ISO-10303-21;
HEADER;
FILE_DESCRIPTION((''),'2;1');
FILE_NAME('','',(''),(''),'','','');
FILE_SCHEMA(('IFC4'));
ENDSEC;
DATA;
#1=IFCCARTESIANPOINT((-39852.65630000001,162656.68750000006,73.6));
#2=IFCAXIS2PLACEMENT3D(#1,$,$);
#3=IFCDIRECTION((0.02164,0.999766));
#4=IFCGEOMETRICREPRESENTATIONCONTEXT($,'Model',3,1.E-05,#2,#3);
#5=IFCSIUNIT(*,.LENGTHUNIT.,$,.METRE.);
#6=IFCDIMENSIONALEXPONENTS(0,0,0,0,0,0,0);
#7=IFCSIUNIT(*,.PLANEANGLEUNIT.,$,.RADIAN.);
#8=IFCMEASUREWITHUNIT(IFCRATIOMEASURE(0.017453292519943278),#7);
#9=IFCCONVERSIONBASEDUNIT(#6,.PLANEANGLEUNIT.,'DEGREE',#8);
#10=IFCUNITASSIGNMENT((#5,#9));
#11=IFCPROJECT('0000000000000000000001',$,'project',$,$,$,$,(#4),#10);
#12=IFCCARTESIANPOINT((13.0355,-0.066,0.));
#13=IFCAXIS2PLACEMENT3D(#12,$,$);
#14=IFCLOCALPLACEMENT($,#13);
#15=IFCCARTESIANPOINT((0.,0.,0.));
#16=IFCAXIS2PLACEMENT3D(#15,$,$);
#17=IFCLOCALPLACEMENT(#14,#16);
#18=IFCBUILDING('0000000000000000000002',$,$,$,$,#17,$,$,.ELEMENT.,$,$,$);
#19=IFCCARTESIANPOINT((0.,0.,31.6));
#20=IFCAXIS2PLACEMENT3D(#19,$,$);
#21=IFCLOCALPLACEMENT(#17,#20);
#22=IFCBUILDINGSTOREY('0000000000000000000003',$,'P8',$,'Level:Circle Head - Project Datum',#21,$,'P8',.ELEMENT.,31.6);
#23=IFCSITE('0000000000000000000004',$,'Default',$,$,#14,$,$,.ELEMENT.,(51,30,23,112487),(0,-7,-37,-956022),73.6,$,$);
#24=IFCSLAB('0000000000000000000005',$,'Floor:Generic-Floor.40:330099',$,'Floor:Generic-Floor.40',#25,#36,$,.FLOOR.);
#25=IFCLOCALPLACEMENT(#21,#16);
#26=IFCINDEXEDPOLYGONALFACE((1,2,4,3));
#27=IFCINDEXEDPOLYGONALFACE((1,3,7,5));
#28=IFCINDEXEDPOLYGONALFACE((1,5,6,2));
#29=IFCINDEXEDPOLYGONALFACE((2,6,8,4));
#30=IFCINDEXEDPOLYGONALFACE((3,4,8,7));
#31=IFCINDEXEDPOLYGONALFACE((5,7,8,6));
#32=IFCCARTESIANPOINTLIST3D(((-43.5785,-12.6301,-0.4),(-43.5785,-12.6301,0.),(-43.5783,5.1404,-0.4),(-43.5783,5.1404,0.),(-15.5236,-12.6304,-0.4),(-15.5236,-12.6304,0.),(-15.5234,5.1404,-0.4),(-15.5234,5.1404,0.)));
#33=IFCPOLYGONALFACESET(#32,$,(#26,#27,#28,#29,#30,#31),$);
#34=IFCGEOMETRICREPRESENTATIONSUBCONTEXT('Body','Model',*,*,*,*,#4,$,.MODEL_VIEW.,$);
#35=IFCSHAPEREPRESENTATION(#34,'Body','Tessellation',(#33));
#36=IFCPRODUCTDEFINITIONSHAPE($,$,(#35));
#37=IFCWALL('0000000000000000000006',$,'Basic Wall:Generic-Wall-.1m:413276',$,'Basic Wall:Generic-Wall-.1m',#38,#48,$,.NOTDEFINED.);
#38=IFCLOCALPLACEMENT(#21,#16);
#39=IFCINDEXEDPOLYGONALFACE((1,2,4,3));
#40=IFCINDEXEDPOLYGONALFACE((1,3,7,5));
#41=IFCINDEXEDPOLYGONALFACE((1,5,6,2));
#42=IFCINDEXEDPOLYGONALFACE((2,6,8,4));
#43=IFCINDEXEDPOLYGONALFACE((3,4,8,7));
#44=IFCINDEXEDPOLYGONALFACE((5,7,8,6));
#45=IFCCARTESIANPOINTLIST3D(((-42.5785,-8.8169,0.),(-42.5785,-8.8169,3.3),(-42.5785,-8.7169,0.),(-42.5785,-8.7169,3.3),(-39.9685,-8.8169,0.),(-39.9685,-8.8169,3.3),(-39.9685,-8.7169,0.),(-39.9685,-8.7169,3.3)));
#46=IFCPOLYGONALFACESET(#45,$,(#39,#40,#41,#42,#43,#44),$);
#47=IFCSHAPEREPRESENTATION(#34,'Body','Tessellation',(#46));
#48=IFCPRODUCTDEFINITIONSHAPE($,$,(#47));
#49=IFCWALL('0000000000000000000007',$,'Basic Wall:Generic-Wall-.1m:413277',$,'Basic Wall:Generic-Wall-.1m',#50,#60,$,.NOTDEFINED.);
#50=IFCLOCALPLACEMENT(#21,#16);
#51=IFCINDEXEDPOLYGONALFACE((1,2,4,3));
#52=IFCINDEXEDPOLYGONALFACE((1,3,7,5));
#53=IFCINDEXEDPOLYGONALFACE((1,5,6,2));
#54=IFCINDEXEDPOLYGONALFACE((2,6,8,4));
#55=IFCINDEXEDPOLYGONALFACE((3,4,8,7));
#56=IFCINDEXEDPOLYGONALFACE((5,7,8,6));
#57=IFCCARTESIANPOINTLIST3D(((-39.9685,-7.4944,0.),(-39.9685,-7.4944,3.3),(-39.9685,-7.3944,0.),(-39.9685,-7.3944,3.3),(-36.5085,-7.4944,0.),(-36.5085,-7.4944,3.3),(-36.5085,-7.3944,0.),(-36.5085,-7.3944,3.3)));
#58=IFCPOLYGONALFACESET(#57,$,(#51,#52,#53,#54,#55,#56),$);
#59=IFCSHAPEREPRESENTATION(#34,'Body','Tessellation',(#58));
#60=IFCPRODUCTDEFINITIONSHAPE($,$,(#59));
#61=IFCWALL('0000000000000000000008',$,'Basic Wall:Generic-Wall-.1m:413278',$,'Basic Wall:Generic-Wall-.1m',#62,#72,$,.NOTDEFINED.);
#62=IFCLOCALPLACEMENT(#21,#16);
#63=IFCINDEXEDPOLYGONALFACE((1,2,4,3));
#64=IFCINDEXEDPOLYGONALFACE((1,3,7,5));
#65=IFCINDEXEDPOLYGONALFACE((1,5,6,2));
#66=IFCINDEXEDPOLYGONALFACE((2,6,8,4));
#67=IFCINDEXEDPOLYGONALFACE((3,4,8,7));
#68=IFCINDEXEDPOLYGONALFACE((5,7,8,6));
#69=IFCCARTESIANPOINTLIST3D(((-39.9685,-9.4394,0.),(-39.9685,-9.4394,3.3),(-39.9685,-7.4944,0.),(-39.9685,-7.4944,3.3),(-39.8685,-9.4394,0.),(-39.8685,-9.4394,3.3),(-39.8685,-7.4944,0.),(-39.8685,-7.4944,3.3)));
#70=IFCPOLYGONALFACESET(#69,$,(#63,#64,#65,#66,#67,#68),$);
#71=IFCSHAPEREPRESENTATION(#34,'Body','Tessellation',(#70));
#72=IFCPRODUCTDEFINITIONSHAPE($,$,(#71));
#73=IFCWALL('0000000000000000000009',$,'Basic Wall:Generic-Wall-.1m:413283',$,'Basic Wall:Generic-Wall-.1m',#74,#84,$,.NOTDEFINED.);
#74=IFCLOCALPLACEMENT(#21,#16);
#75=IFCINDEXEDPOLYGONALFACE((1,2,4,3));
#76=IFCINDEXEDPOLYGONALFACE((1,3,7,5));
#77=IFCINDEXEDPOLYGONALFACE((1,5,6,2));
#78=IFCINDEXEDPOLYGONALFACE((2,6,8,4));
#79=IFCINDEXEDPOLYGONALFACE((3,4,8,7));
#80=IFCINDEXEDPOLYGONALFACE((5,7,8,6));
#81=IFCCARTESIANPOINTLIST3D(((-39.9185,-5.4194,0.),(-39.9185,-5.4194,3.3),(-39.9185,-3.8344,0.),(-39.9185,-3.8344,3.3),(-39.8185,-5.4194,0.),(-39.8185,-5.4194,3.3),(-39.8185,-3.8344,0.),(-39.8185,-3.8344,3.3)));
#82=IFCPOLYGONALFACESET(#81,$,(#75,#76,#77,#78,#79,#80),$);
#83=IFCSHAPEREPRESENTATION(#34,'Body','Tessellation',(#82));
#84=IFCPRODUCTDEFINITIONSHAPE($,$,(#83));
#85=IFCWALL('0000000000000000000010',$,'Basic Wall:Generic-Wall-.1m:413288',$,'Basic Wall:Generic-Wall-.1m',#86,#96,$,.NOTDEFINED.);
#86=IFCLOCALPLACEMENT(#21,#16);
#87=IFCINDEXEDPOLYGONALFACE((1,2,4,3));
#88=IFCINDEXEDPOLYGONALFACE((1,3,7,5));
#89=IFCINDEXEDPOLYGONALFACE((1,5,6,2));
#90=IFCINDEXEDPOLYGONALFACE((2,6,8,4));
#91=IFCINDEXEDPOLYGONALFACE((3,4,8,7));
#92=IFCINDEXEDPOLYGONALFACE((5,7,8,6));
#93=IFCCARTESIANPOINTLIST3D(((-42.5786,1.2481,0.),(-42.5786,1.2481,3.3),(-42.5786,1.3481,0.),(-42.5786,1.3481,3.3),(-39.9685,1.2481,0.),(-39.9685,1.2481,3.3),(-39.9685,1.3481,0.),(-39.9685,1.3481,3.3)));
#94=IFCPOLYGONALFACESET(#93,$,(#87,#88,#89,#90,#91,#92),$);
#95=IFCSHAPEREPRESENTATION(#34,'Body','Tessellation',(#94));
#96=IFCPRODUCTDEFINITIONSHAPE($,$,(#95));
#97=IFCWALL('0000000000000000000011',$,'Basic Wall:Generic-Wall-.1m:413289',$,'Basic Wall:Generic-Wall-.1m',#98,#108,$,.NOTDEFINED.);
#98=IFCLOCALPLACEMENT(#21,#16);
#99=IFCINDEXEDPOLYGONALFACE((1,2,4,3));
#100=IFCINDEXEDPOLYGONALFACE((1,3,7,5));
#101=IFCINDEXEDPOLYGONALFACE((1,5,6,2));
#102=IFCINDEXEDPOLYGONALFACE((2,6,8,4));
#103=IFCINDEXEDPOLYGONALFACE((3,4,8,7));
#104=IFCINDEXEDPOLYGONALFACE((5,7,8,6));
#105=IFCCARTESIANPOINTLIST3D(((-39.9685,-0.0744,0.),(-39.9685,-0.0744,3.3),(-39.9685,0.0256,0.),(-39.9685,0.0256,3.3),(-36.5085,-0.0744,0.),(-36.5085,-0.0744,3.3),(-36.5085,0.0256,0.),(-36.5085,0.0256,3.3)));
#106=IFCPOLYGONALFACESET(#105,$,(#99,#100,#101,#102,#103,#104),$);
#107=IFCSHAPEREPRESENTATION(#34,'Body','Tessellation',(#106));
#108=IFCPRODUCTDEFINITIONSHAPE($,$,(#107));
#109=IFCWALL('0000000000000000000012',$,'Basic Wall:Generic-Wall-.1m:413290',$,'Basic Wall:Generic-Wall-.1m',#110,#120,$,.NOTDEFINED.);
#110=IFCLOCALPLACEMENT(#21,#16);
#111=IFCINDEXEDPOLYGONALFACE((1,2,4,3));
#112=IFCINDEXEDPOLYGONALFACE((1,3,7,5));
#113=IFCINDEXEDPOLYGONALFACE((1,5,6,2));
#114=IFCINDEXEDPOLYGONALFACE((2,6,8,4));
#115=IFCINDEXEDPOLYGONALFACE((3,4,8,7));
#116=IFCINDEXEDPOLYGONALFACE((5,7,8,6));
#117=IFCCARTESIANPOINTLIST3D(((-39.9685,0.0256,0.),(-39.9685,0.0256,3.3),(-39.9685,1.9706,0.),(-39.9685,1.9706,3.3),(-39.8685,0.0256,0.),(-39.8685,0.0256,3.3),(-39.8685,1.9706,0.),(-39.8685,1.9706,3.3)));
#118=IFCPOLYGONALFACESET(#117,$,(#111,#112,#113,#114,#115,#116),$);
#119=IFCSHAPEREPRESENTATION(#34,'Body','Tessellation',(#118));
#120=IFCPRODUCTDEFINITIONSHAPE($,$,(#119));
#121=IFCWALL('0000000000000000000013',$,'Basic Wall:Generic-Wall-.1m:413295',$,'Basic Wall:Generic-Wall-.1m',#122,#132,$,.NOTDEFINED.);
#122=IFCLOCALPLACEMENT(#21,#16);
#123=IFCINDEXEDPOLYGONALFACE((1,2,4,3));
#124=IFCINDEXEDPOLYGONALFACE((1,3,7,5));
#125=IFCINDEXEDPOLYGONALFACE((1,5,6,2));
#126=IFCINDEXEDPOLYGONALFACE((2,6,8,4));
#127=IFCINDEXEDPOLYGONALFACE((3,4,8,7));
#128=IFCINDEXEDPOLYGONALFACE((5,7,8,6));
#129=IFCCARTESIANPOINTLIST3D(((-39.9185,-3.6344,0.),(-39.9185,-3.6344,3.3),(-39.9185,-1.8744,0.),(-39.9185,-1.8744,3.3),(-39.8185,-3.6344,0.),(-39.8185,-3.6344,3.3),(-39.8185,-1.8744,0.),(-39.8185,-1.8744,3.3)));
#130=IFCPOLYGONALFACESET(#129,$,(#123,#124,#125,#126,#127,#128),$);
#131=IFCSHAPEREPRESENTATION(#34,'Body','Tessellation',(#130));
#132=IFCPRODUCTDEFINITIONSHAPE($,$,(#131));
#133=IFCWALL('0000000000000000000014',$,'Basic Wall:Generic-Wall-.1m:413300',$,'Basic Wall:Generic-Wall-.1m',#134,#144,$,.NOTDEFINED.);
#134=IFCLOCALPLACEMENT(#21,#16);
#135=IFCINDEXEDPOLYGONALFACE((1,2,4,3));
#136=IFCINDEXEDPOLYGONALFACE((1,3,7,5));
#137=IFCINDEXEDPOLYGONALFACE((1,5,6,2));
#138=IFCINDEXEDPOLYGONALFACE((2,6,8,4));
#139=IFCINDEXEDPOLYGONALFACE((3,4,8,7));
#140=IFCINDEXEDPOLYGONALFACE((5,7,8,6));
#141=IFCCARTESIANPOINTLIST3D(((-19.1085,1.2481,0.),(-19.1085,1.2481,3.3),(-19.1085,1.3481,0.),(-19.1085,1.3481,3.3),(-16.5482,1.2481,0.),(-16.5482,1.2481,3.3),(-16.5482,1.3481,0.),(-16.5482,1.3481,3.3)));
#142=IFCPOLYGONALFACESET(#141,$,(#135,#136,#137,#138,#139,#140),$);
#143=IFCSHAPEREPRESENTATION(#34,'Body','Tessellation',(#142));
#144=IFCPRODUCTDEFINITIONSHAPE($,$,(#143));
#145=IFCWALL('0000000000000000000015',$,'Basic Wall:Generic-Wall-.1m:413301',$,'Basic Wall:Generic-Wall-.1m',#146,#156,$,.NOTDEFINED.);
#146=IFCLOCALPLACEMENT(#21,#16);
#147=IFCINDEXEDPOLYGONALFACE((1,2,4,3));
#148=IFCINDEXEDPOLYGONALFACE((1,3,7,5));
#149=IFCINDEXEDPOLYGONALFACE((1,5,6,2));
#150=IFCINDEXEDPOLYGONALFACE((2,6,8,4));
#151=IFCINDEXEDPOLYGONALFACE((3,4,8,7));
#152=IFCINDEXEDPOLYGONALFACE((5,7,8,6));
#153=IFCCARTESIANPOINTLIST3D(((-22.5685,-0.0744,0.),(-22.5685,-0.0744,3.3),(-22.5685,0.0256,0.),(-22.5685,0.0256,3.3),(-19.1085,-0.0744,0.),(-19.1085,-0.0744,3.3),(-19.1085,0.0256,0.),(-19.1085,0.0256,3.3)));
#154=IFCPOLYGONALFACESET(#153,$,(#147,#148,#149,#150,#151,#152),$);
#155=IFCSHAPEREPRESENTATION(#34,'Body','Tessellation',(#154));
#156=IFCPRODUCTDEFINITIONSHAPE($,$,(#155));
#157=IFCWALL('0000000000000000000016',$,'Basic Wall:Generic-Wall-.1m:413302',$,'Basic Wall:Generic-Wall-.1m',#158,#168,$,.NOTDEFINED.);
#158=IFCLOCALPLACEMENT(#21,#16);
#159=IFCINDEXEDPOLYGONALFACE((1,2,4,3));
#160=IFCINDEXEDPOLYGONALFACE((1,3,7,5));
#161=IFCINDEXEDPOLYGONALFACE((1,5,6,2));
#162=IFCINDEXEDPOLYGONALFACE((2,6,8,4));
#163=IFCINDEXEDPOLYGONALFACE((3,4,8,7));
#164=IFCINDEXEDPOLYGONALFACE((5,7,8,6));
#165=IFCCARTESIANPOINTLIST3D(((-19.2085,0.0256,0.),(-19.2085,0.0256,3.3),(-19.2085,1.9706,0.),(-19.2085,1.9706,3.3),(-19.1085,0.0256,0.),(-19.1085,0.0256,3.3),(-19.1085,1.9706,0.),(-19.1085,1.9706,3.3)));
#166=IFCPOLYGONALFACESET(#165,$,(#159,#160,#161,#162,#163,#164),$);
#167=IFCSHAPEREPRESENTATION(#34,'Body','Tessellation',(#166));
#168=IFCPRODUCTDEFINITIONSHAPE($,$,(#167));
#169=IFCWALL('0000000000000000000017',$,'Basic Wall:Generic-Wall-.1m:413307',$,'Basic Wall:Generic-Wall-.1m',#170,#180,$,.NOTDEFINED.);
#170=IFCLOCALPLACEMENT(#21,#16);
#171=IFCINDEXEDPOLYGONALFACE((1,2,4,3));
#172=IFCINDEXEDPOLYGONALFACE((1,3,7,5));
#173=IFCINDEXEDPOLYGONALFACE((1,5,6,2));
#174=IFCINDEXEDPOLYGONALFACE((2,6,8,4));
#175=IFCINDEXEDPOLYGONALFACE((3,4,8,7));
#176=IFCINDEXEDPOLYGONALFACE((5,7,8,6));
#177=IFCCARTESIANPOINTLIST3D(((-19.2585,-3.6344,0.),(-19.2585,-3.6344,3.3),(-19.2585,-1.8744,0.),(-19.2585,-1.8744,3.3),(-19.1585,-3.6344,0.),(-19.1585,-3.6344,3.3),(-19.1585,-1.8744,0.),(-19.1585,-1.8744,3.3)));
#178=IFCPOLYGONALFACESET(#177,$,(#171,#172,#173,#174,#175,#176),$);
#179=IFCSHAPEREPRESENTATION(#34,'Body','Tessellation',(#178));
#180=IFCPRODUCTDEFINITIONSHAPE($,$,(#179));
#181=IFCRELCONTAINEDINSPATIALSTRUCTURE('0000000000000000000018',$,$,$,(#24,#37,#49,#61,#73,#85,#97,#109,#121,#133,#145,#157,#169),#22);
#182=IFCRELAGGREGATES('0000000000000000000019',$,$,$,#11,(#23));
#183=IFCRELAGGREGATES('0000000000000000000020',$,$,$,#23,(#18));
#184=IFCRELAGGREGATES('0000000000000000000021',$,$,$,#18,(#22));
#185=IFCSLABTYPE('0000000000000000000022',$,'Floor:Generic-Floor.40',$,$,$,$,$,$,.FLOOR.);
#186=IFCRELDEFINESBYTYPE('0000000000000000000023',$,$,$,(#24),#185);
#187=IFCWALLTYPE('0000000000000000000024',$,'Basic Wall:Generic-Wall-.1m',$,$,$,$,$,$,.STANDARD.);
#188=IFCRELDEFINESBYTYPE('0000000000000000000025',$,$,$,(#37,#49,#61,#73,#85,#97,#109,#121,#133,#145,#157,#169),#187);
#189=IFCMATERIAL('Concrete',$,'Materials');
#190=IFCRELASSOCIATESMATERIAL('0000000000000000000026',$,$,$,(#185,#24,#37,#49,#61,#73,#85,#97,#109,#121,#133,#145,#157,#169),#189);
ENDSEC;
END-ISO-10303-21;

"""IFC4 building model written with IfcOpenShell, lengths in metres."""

from ifc_helpers import new_model, entity, si_unit, converted_unit, direction, frame, origin, place, context, subcontext, project, spatial, indexed_curve, outline, extrude, material, type_object, element, save


model = new_model("IFC4")

# Units and contexts
model_context = context("Model", 3, precision=1e-05, world=frame((-39852.65630000001, 162656.68750000006, 73.6)), true_north=direction((0.02164, 0.999766)))
body_context = subcontext(model_context, "Body", "Model", "MODEL_VIEW")
ifc_project = project(units=[si_unit("LENGTHUNIT", "METRE"), converted_unit("PLANEANGLEUNIT", "DEGREE", entity("IfcRatioMeasure", 0.017453292519943278), si_unit("PLANEANGLEUNIT", "RADIAN"), dimensions=[0, 0, 0, 0, 0, 0, 0])], contexts=[model_context])

# Site, building, storey
site_placement = place(None, frame((13.0355, -0.066, 0.0)))
site = spatial("IfcSite", under=ifc_project, at=site_placement, Name="Default", CompositionType="ELEMENT", RefLatitude=(51, 30, 23, 112487), RefLongitude=(0, -7, -37, -956022), RefElevation=73.6)
building_placement = place(site_placement, origin())
building = spatial("IfcBuilding", under=site, at=building_placement, CompositionType="ELEMENT")
storey_placement = place(building_placement, frame((0.0, 0.0, 31.6)))
storey = spatial("IfcBuildingStorey", under=building, at=storey_placement, Name="P8", ObjectType="Level:Circle Head - Project Datum", LongName="P8", CompositionType="ELEMENT", Elevation=31.6)

# Shared definitions
ifc_material = material(Name="Concrete", Category="Materials")

# Slab
slab_type = type_object("IfcSlabType", Name="Floor:Generic-Floor.40", PredefinedType="FLOOR", material=ifc_material)
slab_placement = place(storey_placement, origin())
element("IfcSlab", 1, at=slab_placement, inside=storey, type_object=slab_type, material=ifc_material, Name="Floor:Generic-Floor.40:330099", ObjectType="Floor:Generic-Floor.40", PredefinedType="FLOOR", context=body_context, shape_type="SweptSolid", body=[
    extrude(outline(indexed_curve([(-14.0274, -8.8853), (14.0275, -8.8853), (14.0274, 8.8855), (-14.0275, 8.8852), (-14.0274, -8.8853)], self_intersect=False)), frame((-29.5509, -3.7449, 0.0), z_axis=(0.0, 0.0, -1.0), x_axis=(1.0, 0.0, 0.0)), (0.0, 0.0, 1.0), 0.4),
])

# Walls
wall_type = type_object("IfcWallType", Name="Basic Wall:Generic-Wall-.1m", PredefinedType="STANDARD")
wall_1_placement = place(storey_placement, frame((-39.9685, -8.7669, 0.0), z_axis=(0.0, 0.0, 1.0), x_axis=(-1.0, 0.0, 0.0)))
element("IfcWall", 2, at=wall_1_placement, inside=storey, type_object=wall_type, material=ifc_material, Name="Basic Wall:Generic-Wall-.1m:413276", ObjectType="Basic Wall:Generic-Wall-.1m", PredefinedType="NOTDEFINED", context=body_context, shape_type="SweptSolid", body=[
    extrude(outline(indexed_curve([(2.61, 0.05), (0.0, 0.05), (0.0, -0.05), (2.61, -0.05), (2.61, 0.05)], self_intersect=False)), origin(), (0.0, 0.0, 1.0), 3.3),
])
wall_2_placement = place(storey_placement, frame((-36.5085, -7.4444, 0.0), z_axis=(0.0, 0.0, 1.0), x_axis=(-1.0, 0.0, 0.0)))
element("IfcWall", 3, at=wall_2_placement, inside=storey, type_object=wall_type, material=ifc_material, Name="Basic Wall:Generic-Wall-.1m:413277", ObjectType="Basic Wall:Generic-Wall-.1m", PredefinedType="NOTDEFINED", context=body_context, shape_type="SweptSolid", body=[
    extrude(outline(indexed_curve([(3.46, 0.05), (0.0, 0.05), (0.0, -0.05), (3.46, -0.05), (3.46, 0.05)], self_intersect=False)), origin(), (0.0, 0.0, 1.0), 3.3),
])
wall_3_placement = place(storey_placement, frame((-39.9185, -7.4944, 0.0), z_axis=(0.0, 0.0, 1.0), x_axis=(0.0, -1.0, 0.0)))
element("IfcWall", 4, at=wall_3_placement, inside=storey, type_object=wall_type, material=ifc_material, Name="Basic Wall:Generic-Wall-.1m:413278", ObjectType="Basic Wall:Generic-Wall-.1m", PredefinedType="NOTDEFINED", context=body_context, shape_type="SweptSolid", body=[
    extrude(outline(indexed_curve([(1.945, 0.05), (0.0, 0.05), (0.0, -0.05), (1.945, -0.05), (1.945, 0.05)], self_intersect=False)), origin(), (0.0, 0.0, 1.0), 3.3),
])
wall_4_placement = place(storey_placement, frame((-39.8685, -5.4194, 0.0), z_axis=(0.0, 0.0, 1.0), x_axis=(0.0, 1.0, 0.0)))
element("IfcWall", 5, at=wall_4_placement, inside=storey, type_object=wall_type, material=ifc_material, Name="Basic Wall:Generic-Wall-.1m:413283", ObjectType="Basic Wall:Generic-Wall-.1m", PredefinedType="NOTDEFINED", context=body_context, shape_type="SweptSolid", body=[
    extrude(outline(indexed_curve([(1.585, 0.05), (0.0, 0.05), (0.0, -0.05), (1.585, -0.05), (1.585, 0.05)], self_intersect=False)), origin(), (0.0, 0.0, 1.0), 3.3),
])
wall_5_placement = place(storey_placement, frame((-39.9685, 1.2981, 0.0), z_axis=(0.0, 0.0, 1.0), x_axis=(-1.0, 0.0, 0.0)))
element("IfcWall", 6, at=wall_5_placement, inside=storey, type_object=wall_type, material=ifc_material, Name="Basic Wall:Generic-Wall-.1m:413288", ObjectType="Basic Wall:Generic-Wall-.1m", PredefinedType="NOTDEFINED", context=body_context, shape_type="SweptSolid", body=[
    extrude(outline(indexed_curve([(2.6101, 0.05), (0.0, 0.05), (0.0, -0.05), (2.6101, -0.05), (2.6101, 0.05)], self_intersect=False)), origin(), (0.0, 0.0, 1.0), 3.3),
])
wall_6_placement = place(storey_placement, frame((-36.5085, -0.0244, 0.0), z_axis=(0.0, 0.0, 1.0), x_axis=(-1.0, 0.0, 0.0)))
element("IfcWall", 7, at=wall_6_placement, inside=storey, type_object=wall_type, material=ifc_material, Name="Basic Wall:Generic-Wall-.1m:413289", ObjectType="Basic Wall:Generic-Wall-.1m", PredefinedType="NOTDEFINED", context=body_context, shape_type="SweptSolid", body=[
    extrude(outline(indexed_curve([(3.46, 0.05), (0.0, 0.05), (0.0, -0.05), (3.46, -0.05), (3.46, 0.05)], self_intersect=False)), origin(), (0.0, 0.0, 1.0), 3.3),
])
wall_7_placement = place(storey_placement, frame((-39.9185, 0.0256, 0.0), z_axis=(0.0, 0.0, 1.0), x_axis=(0.0, 1.0, 0.0)))
element("IfcWall", 8, at=wall_7_placement, inside=storey, type_object=wall_type, material=ifc_material, Name="Basic Wall:Generic-Wall-.1m:413290", ObjectType="Basic Wall:Generic-Wall-.1m", PredefinedType="NOTDEFINED", context=body_context, shape_type="SweptSolid", body=[
    extrude(outline(indexed_curve([(1.945, 0.05), (0.0, 0.05), (0.0, -0.05), (1.945, -0.05), (1.945, 0.05)], self_intersect=False)), origin(), (0.0, 0.0, 1.0), 3.3),
])
wall_8_placement = place(storey_placement, frame((-39.8685, -1.8744, 0.0), z_axis=(0.0, 0.0, 1.0), x_axis=(0.0, -1.0, 0.0)))
element("IfcWall", 9, at=wall_8_placement, inside=storey, type_object=wall_type, material=ifc_material, Name="Basic Wall:Generic-Wall-.1m:413295", ObjectType="Basic Wall:Generic-Wall-.1m", PredefinedType="NOTDEFINED", context=body_context, shape_type="SweptSolid", body=[
    extrude(outline(indexed_curve([(1.76, 0.05), (0.0, 0.05), (0.0, -0.05), (1.76, -0.05), (1.76, 0.05)], self_intersect=False)), origin(), (0.0, 0.0, 1.0), 3.3),
])
wall_9_placement = place(storey_placement, frame((-19.1085, 1.2981, 0.0)))
element("IfcWall", 10, at=wall_9_placement, inside=storey, type_object=wall_type, material=ifc_material, Name="Basic Wall:Generic-Wall-.1m:413300", ObjectType="Basic Wall:Generic-Wall-.1m", PredefinedType="NOTDEFINED", context=body_context, shape_type="SweptSolid", body=[
    extrude(outline(indexed_curve([(2.5602, 0.05), (0.0, 0.05), (0.0, -0.05), (2.5602, -0.05), (2.5602, 0.05)], self_intersect=False)), origin(), (0.0, 0.0, 1.0), 3.3),
])
wall_10_placement = place(storey_placement, frame((-22.5685, -0.0244, 0.0)))
element("IfcWall", 11, at=wall_10_placement, inside=storey, type_object=wall_type, material=ifc_material, Name="Basic Wall:Generic-Wall-.1m:413301", ObjectType="Basic Wall:Generic-Wall-.1m", PredefinedType="NOTDEFINED", context=body_context, shape_type="SweptSolid", body=[
    extrude(outline(indexed_curve([(3.46, 0.05), (0.0, 0.05), (0.0, -0.05), (3.46, -0.05), (3.46, 0.05)], self_intersect=False)), origin(), (0.0, 0.0, 1.0), 3.3),
])
wall_11_placement = place(storey_placement, frame((-19.1585, 0.0256, 0.0), z_axis=(0.0, 0.0, 1.0), x_axis=(0.0, 1.0, 0.0)))
element("IfcWall", 12, at=wall_11_placement, inside=storey, type_object=wall_type, material=ifc_material, Name="Basic Wall:Generic-Wall-.1m:413302", ObjectType="Basic Wall:Generic-Wall-.1m", PredefinedType="NOTDEFINED", context=body_context, shape_type="SweptSolid", body=[
    extrude(outline(indexed_curve([(1.945, 0.05), (0.0, 0.05), (0.0, -0.05), (1.945, -0.05), (1.945, 0.05)], self_intersect=False)), origin(), (0.0, 0.0, 1.0), 3.3),
])
wall_12_placement = place(storey_placement, frame((-19.2085, -1.8744, 0.0), z_axis=(0.0, 0.0, 1.0), x_axis=(0.0, -1.0, 0.0)))
element("IfcWall", 13, at=wall_12_placement, inside=storey, type_object=wall_type, material=ifc_material, Name="Basic Wall:Generic-Wall-.1m:413307", ObjectType="Basic Wall:Generic-Wall-.1m", PredefinedType="NOTDEFINED", context=body_context, shape_type="SweptSolid", body=[
    extrude(outline(indexed_curve([(1.76, 0.05), (0.0, 0.05), (0.0, -0.05), (1.76, -0.05), (1.76, 0.05)], self_intersect=False)), origin(), (0.0, 0.0, 1.0), 3.3),
])

save(model, "model.ifc")
